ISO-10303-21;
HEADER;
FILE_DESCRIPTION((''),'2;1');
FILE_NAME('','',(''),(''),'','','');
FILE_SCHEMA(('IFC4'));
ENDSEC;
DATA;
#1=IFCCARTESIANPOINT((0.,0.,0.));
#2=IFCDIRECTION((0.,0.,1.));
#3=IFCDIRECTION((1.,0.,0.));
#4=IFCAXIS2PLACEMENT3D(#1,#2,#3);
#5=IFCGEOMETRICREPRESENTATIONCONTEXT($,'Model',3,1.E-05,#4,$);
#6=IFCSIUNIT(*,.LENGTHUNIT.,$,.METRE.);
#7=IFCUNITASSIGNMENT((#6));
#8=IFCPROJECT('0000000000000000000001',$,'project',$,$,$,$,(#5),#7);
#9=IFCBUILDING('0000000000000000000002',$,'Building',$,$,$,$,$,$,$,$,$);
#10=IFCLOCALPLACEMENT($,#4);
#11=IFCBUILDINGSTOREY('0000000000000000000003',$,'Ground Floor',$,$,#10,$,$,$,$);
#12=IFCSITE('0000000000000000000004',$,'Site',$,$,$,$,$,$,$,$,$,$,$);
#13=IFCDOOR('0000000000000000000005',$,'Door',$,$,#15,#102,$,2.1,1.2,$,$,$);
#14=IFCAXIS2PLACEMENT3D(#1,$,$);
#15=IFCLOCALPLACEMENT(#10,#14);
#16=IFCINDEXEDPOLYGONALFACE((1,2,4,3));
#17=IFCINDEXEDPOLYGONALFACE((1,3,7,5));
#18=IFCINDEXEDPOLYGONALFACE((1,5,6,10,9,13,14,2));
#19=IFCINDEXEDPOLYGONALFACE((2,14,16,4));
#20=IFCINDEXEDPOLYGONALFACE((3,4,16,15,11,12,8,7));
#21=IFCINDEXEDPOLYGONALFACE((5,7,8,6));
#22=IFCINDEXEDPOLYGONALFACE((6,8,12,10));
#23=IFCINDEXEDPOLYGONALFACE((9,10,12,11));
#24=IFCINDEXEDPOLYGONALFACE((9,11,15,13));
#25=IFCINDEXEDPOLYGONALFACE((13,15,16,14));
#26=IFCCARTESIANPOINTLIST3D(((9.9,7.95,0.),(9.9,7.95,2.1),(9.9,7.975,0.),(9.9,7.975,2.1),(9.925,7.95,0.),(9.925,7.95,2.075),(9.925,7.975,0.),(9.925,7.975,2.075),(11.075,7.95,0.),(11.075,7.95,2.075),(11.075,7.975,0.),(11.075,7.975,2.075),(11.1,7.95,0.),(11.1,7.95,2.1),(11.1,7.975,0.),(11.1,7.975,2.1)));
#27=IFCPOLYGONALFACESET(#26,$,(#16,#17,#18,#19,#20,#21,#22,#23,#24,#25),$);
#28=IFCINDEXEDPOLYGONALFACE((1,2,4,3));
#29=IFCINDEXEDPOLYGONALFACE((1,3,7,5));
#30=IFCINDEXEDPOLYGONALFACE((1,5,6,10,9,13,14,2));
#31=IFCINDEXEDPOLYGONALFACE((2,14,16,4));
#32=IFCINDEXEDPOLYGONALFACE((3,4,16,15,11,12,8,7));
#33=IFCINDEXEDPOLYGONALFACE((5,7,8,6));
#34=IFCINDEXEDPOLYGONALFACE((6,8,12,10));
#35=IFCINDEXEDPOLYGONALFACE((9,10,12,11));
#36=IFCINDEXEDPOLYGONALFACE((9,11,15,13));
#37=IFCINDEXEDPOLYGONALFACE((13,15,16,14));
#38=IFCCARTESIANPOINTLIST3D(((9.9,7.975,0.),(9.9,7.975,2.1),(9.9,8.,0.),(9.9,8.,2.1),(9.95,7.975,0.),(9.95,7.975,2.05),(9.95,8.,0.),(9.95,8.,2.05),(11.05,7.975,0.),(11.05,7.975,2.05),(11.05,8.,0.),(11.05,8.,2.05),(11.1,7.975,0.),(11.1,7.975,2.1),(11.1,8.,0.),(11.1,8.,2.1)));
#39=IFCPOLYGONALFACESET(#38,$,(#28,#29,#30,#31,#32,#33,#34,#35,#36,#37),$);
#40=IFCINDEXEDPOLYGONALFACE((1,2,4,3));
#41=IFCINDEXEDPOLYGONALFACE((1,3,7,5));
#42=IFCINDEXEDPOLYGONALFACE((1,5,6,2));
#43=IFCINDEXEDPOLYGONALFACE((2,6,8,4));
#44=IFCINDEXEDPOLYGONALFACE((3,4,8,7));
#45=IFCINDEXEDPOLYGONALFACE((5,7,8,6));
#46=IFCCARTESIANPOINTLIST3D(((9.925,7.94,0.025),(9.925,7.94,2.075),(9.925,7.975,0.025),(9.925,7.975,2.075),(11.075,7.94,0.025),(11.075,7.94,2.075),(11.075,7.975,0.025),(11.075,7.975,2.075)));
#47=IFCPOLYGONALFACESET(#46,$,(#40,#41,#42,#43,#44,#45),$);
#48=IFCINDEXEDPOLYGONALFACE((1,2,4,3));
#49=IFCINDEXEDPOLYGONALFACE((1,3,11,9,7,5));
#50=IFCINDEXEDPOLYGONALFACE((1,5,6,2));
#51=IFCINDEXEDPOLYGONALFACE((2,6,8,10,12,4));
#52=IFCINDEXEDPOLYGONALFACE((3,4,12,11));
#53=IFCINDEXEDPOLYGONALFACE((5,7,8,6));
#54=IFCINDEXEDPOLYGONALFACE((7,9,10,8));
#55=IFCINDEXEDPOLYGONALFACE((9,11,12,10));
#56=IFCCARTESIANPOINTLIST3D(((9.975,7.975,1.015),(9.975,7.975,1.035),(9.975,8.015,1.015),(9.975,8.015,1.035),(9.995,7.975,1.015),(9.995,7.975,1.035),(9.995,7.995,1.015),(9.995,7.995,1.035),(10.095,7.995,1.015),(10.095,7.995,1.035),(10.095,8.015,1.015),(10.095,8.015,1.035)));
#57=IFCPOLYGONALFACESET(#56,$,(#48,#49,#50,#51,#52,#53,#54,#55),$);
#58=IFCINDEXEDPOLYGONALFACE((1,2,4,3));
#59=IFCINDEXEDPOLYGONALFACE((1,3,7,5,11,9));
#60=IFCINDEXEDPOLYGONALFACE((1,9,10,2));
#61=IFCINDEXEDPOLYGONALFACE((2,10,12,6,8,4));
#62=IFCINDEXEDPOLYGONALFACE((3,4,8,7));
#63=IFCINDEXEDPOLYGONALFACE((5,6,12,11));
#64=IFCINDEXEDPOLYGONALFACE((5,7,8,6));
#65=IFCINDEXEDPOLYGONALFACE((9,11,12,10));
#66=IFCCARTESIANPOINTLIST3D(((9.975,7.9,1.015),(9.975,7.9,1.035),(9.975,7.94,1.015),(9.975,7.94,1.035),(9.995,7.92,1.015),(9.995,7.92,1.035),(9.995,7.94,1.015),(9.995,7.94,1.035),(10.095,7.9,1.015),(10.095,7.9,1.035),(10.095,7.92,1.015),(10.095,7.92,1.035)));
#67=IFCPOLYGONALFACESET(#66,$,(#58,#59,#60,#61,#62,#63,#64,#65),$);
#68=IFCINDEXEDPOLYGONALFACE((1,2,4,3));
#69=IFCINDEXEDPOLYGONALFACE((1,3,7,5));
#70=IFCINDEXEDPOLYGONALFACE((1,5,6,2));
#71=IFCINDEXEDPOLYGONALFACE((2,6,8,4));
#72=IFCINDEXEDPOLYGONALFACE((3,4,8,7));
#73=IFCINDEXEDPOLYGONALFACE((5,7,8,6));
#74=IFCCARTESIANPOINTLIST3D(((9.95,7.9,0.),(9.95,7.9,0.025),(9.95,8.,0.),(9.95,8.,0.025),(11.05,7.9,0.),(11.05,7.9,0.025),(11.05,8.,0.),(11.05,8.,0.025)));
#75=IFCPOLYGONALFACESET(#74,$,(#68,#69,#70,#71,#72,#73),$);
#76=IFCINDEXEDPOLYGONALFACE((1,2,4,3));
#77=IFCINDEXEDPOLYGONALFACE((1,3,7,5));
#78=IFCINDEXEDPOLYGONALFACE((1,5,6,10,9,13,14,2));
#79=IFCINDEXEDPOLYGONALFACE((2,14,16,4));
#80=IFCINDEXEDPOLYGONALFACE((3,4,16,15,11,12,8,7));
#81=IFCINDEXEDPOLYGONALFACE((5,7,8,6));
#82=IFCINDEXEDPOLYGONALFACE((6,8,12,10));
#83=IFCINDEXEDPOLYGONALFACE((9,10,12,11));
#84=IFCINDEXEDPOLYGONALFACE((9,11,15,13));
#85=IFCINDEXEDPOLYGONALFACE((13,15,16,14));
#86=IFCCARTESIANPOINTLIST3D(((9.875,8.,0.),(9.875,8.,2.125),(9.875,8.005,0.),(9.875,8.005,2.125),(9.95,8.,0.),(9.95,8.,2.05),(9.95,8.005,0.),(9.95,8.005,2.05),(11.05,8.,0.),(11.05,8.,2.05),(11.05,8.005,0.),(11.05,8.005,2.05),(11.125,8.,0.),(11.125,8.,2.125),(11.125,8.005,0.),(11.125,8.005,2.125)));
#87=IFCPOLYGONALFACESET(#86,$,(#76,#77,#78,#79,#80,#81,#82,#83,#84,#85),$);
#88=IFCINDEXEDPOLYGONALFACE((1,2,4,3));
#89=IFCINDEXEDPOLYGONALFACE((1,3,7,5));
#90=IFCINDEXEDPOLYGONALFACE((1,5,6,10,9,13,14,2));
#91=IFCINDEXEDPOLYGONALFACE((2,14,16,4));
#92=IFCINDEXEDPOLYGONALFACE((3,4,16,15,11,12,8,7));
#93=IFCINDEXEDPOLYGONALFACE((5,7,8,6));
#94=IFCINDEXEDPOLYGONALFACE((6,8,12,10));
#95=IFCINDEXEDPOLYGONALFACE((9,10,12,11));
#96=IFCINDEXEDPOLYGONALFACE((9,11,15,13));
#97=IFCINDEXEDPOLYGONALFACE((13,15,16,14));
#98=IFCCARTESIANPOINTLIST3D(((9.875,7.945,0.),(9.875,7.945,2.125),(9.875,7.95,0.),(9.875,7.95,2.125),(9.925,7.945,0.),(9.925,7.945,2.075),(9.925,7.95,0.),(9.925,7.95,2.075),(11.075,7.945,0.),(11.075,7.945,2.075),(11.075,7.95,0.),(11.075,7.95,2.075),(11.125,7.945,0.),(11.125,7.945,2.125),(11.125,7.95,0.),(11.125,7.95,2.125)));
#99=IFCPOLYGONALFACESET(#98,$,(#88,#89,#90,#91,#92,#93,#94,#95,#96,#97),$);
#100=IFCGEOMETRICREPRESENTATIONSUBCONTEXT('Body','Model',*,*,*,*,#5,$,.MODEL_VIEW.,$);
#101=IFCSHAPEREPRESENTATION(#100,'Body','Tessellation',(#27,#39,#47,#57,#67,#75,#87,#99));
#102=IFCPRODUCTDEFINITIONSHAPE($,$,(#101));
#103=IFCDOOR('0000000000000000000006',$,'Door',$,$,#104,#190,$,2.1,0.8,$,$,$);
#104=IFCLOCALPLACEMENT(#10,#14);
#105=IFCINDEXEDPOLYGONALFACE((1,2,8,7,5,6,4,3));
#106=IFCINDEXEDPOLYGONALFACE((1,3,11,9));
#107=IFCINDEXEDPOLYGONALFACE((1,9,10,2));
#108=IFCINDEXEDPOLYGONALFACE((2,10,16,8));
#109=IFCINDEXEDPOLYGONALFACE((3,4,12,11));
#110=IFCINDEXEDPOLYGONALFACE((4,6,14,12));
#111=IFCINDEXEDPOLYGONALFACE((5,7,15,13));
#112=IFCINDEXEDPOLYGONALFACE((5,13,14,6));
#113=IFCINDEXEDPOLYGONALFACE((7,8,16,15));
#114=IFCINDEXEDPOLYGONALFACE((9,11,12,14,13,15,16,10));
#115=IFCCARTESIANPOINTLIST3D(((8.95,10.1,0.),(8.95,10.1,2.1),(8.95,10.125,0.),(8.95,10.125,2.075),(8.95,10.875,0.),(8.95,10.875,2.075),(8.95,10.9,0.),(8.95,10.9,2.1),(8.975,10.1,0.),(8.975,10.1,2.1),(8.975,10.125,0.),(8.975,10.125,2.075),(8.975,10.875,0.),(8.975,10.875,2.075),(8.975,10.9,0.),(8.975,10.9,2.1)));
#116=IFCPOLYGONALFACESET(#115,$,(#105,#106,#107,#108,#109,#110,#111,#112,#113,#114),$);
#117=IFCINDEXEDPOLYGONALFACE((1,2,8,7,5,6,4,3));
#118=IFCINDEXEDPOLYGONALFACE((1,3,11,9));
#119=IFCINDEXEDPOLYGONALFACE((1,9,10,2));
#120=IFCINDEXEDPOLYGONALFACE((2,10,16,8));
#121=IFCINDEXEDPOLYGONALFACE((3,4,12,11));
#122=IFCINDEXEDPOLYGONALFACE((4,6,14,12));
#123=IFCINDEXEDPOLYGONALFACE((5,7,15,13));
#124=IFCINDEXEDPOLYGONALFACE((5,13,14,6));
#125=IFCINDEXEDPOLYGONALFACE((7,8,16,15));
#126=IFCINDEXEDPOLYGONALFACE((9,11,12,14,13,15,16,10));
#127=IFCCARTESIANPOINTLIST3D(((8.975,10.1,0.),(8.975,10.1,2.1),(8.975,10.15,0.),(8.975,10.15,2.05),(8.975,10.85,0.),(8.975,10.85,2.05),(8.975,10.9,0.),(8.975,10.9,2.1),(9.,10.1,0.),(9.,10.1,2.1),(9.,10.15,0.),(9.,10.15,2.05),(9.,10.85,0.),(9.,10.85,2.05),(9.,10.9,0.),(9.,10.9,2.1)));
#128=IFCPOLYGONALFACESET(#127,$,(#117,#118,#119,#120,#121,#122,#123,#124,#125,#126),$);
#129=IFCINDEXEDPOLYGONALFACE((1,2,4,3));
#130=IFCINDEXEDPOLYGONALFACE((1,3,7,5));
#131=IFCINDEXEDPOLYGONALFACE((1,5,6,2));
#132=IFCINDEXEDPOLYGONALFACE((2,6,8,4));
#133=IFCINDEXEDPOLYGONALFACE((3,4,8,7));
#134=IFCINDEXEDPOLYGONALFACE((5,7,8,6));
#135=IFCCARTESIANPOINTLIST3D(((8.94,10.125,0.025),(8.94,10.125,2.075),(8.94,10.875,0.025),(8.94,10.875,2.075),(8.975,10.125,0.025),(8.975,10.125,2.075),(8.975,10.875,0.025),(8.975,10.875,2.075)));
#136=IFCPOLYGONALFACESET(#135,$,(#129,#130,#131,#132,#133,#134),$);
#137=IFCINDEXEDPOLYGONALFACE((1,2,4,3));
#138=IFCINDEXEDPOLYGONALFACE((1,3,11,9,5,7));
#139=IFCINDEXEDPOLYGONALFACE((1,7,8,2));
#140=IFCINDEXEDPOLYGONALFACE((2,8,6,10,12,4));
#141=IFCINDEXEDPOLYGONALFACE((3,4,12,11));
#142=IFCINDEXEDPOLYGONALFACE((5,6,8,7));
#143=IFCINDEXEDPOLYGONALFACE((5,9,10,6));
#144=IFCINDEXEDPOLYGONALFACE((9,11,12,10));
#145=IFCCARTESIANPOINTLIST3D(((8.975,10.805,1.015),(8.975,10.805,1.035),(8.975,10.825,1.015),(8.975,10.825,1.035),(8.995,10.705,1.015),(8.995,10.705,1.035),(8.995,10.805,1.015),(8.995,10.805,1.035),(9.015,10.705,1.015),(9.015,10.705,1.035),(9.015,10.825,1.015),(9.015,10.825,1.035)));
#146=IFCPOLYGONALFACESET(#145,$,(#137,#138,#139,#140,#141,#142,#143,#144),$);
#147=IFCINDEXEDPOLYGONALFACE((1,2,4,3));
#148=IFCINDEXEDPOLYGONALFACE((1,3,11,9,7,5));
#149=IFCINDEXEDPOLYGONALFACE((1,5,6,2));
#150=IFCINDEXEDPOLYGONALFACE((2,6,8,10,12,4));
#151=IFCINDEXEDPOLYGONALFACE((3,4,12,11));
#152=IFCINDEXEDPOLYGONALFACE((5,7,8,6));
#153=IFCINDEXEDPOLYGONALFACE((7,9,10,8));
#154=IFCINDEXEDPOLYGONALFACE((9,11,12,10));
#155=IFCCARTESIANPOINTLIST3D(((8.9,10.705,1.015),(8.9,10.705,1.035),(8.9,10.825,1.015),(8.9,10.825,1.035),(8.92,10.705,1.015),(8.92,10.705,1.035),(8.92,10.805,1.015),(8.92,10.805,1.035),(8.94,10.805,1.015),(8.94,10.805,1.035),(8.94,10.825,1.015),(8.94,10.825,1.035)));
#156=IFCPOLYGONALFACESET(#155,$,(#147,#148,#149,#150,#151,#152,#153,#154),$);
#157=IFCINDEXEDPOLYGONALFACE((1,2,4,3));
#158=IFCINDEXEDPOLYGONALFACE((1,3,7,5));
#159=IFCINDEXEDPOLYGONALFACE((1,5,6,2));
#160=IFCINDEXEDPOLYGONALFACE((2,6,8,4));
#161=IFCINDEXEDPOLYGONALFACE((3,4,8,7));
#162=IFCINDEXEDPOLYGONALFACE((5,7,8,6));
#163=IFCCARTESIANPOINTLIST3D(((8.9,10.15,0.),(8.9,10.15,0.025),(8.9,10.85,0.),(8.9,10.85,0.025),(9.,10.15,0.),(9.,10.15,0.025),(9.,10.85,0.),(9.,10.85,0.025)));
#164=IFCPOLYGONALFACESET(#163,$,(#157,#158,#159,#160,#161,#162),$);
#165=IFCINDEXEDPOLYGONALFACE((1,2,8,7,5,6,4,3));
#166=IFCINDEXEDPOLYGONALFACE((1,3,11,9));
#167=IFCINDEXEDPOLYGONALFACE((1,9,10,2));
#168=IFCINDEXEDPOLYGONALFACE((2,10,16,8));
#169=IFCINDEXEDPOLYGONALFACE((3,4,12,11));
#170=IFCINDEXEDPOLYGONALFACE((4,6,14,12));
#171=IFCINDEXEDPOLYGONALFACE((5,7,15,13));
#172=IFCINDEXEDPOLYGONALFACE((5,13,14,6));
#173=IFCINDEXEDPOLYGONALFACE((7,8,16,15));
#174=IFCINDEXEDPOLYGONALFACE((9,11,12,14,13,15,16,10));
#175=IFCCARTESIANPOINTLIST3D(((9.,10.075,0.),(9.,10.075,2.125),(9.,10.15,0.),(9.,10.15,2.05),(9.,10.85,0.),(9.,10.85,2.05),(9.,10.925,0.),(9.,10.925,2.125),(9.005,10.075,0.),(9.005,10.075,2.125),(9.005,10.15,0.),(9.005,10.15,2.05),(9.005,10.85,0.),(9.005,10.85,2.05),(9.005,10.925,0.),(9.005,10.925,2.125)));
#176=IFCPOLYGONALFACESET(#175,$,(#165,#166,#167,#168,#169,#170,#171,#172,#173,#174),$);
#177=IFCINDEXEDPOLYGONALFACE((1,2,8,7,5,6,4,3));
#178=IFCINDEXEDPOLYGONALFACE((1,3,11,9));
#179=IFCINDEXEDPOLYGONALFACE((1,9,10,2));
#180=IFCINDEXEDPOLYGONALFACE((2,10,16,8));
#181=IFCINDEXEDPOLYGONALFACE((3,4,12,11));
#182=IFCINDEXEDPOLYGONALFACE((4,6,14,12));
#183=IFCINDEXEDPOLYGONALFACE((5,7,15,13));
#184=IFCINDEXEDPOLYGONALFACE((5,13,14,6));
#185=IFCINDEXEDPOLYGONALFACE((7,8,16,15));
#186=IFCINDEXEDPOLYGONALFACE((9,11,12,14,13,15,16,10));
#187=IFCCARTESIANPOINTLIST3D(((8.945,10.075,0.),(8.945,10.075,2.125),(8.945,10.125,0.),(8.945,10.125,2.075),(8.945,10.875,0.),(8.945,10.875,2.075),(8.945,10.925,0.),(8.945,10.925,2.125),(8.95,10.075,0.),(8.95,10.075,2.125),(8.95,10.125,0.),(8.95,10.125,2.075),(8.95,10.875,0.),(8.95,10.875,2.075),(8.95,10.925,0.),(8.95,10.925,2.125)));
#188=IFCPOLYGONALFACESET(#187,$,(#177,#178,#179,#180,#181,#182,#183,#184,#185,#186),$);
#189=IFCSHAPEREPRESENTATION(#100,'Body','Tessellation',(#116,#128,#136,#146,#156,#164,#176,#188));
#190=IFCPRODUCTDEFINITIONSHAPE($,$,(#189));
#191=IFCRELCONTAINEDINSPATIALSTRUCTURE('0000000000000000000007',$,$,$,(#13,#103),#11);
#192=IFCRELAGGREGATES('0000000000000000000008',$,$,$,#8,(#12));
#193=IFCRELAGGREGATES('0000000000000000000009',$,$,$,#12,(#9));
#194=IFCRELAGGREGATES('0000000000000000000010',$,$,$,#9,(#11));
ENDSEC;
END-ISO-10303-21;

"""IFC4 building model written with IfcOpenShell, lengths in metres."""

from ifc_helpers import new_model, si_unit, frame, origin_with_axes, place, context, subcontext, project, spatial, line, indexed_curve, outline, extrude, element, save


model = new_model("IFC4")

# Units and contexts
model_context = context("Model", 3, precision=1e-05, world=origin_with_axes())
body_context = subcontext(model_context, "Body", "Model", "MODEL_VIEW")
ifc_project = project(units=[si_unit("LENGTHUNIT", "METRE")], contexts=[model_context])

# Site, building, storey
site = spatial("IfcSite", under=ifc_project, Name="Site")
building = spatial("IfcBuilding", under=site, Name="Building")
storey_placement = place(None, origin_with_axes())
storey = spatial("IfcBuildingStorey", under=building, at=storey_placement, Name="Ground Floor")

# Doors
door_1_placement = place(storey_placement, frame((11.1, 8.0, 0.0), z_axis=(0.0, 0.0, 1.0), x_axis=(-1.0, 0.0, 0.0)))
element("IfcDoor", 1, at=door_1_placement, inside=storey, Name="Door", OverallHeight=2.1, OverallWidth=1.2, context=body_context, shape_type="SweptSolid", body=[
    extrude(outline(indexed_curve([(0.0, 0.0), (0.0, 2.1), (1.2, 2.1), (1.2, 0.0), (1.175, 0.0), (1.175, 2.075), (0.025, 2.075), (0.025, 0.0)], segments=[line(1, 2, 3, 4, 5, 6, 7, 8, 1)])), frame((0.0, 0.025, 0.0), z_axis=(0.0, -1.0, 0.0), x_axis=(1.0, 0.0, 0.0)), (0.0, 0.0, -1.0), 0.025),
    extrude(outline(indexed_curve([(0.0, 0.0), (0.0, 2.1), (1.2, 2.1), (1.2, 0.0), (1.15, 0.0), (1.15, 2.05), (0.05, 2.05), (0.05, 0.0)], segments=[line(1, 2, 3, 4, 5, 6, 7, 8, 1)])), frame((0.0, 0.0, 0.0), z_axis=(0.0, -1.0, 0.0), x_axis=(1.0, 0.0, 0.0)), (0.0, 0.0, -1.0), 0.025),
    extrude(outline(indexed_curve([(0.0, 0.0), (1.15, 0.0), (1.15, 0.035), (0.0, 0.035)], segments=[line(1, 2, 3, 4, 1)])), frame((0.025, 0.025, 0.025), z_axis=(0.0, 0.0, 1.0), x_axis=(1.0, 0.0, 0.0)), (0.0, 0.0, 1.0), 2.05),
    extrude(outline(indexed_curve([(0.0, 0.0), (0.0, -0.04), (-0.12, -0.04), (-0.12, -0.02), (-0.02, -0.02), (-0.02, 0.0)], segments=[line(1, 2, 3, 4, 5, 6, 1)])), frame((1.125, 0.025, 1.015), z_axis=(0.0, 0.0, 1.0), x_axis=(1.0, 0.0, 0.0)), (0.0, 0.0, 1.0), 0.02),
    extrude(outline(indexed_curve([(0.0, 0.0), (0.0, 0.04), (-0.12, 0.04), (-0.12, 0.02), (-0.02, 0.02), (-0.02, 0.0)], segments=[line(1, 2, 3, 4, 5, 6, 1)])), frame((1.125, 0.06, 1.015), z_axis=(0.0, 0.0, 1.0), x_axis=(1.0, 0.0, 0.0)), (0.0, 0.0, 1.0), 0.02),
    extrude(outline(indexed_curve([(0.0, 0.0), (1.1, 0.0), (1.1, 0.1), (0.0, 0.1)], segments=[line(1, 2, 3, 4, 1)])), frame((0.05, 0.0, 0.0), z_axis=(0.0, 0.0, 1.0), x_axis=(1.0, 0.0, 0.0)), (0.0, 0.0, 1.0), 0.025),
    extrude(outline(indexed_curve([(0.0, 0.0), (0.0, 2.125), (1.25, 2.125), (1.25, 0.0), (1.175, 0.0), (1.175, 2.05), (0.075, 2.05), (0.075, 0.0)], segments=[line(1, 2, 3, 4, 5, 6, 7, 8, 1)])), frame((-0.025, -0.005, 0.0), z_axis=(0.0, -1.0, 0.0), x_axis=(1.0, 0.0, 0.0)), (0.0, 0.0, -1.0), 0.005),
    extrude(outline(indexed_curve([(0.0, 0.0), (0.0, 2.125), (1.25, 2.125), (1.25, 0.0), (1.2, 0.0), (1.2, 2.075), (0.05, 2.075), (0.05, 0.0)], segments=[line(1, 2, 3, 4, 5, 6, 7, 8, 1)])), frame((-0.025, 0.05, 0.0), z_axis=(0.0, -1.0, 0.0), x_axis=(1.0, 0.0, 0.0)), (0.0, 0.0, -1.0), 0.005),
])
door_2_placement = place(storey_placement, frame((9.0, 10.1, 0.0), z_axis=(0.0, 0.0, 1.0), x_axis=(0.0, 1.0, 0.0)))
element("IfcDoor", 2, at=door_2_placement, inside=storey, Name="Door", OverallHeight=2.1, OverallWidth=0.8, context=body_context, shape_type="SweptSolid", body=[
    extrude(outline(indexed_curve([(0.0, 0.0), (0.0, 2.1), (0.8, 2.1), (0.8, 0.0), (0.775, 0.0), (0.775, 2.075), (0.025, 2.075), (0.025, 0.0)], segments=[line(1, 2, 3, 4, 5, 6, 7, 8, 1)])), frame((0.0, 0.025, 0.0), z_axis=(0.0, -1.0, 0.0), x_axis=(1.0, 0.0, 0.0)), (0.0, 0.0, -1.0), 0.025),
    extrude(outline(indexed_curve([(0.0, 0.0), (0.0, 2.1), (0.8, 2.1), (0.8, 0.0), (0.75, 0.0), (0.75, 2.05), (0.05, 2.05), (0.05, 0.0)], segments=[line(1, 2, 3, 4, 5, 6, 7, 8, 1)])), frame((0.0, 0.0, 0.0), z_axis=(0.0, -1.0, 0.0), x_axis=(1.0, 0.0, 0.0)), (0.0, 0.0, -1.0), 0.025),
    extrude(outline(indexed_curve([(0.0, 0.0), (0.75, 0.0), (0.75, 0.035), (0.0, 0.035)], segments=[line(1, 2, 3, 4, 1)])), frame((0.025, 0.025, 0.025), z_axis=(0.0, 0.0, 1.0), x_axis=(1.0, 0.0, 0.0)), (0.0, 0.0, 1.0), 2.05),
    extrude(outline(indexed_curve([(0.0, 0.0), (0.0, -0.04), (-0.12, -0.04), (-0.12, -0.02), (-0.02, -0.02), (-0.02, 0.0)], segments=[line(1, 2, 3, 4, 5, 6, 1)])), frame((0.725, 0.025, 1.015), z_axis=(0.0, 0.0, 1.0), x_axis=(1.0, 0.0, 0.0)), (0.0, 0.0, 1.0), 0.02),
    extrude(outline(indexed_curve([(0.0, 0.0), (0.0, 0.04), (-0.12, 0.04), (-0.12, 0.02), (-0.02, 0.02), (-0.02, 0.0)], segments=[line(1, 2, 3, 4, 5, 6, 1)])), frame((0.725, 0.06, 1.015), z_axis=(0.0, 0.0, 1.0), x_axis=(1.0, 0.0, 0.0)), (0.0, 0.0, 1.0), 0.02),
    extrude(outline(indexed_curve([(0.0, 0.0), (0.7, 0.0), (0.7, 0.1), (0.0, 0.1)], segments=[line(1, 2, 3, 4, 1)])), frame((0.05, 0.0, 0.0), z_axis=(0.0, 0.0, 1.0), x_axis=(1.0, 0.0, 0.0)), (0.0, 0.0, 1.0), 0.025),
    extrude(outline(indexed_curve([(0.0, 0.0), (0.0, 2.125), (0.85, 2.125), (0.85, 0.0), (0.775, 0.0), (0.775, 2.05), (0.075, 2.05), (0.075, 0.0)], segments=[line(1, 2, 3, 4, 5, 6, 7, 8, 1)])), frame((-0.025, -0.005, 0.0), z_axis=(0.0, -1.0, 0.0), x_axis=(1.0, 0.0, 0.0)), (0.0, 0.0, -1.0), 0.005),
    extrude(outline(indexed_curve([(0.0, 0.0), (0.0, 2.125), (0.85, 2.125), (0.85, 0.0), (0.8, 0.0), (0.8, 2.075), (0.05, 2.075), (0.05, 0.0)], segments=[line(1, 2, 3, 4, 5, 6, 7, 8, 1)])), frame((-0.025, 0.05, 0.0), z_axis=(0.0, -1.0, 0.0), x_axis=(1.0, 0.0, 0.0)), (0.0, 0.0, -1.0), 0.005),
])

save(model, "model.ifc")
